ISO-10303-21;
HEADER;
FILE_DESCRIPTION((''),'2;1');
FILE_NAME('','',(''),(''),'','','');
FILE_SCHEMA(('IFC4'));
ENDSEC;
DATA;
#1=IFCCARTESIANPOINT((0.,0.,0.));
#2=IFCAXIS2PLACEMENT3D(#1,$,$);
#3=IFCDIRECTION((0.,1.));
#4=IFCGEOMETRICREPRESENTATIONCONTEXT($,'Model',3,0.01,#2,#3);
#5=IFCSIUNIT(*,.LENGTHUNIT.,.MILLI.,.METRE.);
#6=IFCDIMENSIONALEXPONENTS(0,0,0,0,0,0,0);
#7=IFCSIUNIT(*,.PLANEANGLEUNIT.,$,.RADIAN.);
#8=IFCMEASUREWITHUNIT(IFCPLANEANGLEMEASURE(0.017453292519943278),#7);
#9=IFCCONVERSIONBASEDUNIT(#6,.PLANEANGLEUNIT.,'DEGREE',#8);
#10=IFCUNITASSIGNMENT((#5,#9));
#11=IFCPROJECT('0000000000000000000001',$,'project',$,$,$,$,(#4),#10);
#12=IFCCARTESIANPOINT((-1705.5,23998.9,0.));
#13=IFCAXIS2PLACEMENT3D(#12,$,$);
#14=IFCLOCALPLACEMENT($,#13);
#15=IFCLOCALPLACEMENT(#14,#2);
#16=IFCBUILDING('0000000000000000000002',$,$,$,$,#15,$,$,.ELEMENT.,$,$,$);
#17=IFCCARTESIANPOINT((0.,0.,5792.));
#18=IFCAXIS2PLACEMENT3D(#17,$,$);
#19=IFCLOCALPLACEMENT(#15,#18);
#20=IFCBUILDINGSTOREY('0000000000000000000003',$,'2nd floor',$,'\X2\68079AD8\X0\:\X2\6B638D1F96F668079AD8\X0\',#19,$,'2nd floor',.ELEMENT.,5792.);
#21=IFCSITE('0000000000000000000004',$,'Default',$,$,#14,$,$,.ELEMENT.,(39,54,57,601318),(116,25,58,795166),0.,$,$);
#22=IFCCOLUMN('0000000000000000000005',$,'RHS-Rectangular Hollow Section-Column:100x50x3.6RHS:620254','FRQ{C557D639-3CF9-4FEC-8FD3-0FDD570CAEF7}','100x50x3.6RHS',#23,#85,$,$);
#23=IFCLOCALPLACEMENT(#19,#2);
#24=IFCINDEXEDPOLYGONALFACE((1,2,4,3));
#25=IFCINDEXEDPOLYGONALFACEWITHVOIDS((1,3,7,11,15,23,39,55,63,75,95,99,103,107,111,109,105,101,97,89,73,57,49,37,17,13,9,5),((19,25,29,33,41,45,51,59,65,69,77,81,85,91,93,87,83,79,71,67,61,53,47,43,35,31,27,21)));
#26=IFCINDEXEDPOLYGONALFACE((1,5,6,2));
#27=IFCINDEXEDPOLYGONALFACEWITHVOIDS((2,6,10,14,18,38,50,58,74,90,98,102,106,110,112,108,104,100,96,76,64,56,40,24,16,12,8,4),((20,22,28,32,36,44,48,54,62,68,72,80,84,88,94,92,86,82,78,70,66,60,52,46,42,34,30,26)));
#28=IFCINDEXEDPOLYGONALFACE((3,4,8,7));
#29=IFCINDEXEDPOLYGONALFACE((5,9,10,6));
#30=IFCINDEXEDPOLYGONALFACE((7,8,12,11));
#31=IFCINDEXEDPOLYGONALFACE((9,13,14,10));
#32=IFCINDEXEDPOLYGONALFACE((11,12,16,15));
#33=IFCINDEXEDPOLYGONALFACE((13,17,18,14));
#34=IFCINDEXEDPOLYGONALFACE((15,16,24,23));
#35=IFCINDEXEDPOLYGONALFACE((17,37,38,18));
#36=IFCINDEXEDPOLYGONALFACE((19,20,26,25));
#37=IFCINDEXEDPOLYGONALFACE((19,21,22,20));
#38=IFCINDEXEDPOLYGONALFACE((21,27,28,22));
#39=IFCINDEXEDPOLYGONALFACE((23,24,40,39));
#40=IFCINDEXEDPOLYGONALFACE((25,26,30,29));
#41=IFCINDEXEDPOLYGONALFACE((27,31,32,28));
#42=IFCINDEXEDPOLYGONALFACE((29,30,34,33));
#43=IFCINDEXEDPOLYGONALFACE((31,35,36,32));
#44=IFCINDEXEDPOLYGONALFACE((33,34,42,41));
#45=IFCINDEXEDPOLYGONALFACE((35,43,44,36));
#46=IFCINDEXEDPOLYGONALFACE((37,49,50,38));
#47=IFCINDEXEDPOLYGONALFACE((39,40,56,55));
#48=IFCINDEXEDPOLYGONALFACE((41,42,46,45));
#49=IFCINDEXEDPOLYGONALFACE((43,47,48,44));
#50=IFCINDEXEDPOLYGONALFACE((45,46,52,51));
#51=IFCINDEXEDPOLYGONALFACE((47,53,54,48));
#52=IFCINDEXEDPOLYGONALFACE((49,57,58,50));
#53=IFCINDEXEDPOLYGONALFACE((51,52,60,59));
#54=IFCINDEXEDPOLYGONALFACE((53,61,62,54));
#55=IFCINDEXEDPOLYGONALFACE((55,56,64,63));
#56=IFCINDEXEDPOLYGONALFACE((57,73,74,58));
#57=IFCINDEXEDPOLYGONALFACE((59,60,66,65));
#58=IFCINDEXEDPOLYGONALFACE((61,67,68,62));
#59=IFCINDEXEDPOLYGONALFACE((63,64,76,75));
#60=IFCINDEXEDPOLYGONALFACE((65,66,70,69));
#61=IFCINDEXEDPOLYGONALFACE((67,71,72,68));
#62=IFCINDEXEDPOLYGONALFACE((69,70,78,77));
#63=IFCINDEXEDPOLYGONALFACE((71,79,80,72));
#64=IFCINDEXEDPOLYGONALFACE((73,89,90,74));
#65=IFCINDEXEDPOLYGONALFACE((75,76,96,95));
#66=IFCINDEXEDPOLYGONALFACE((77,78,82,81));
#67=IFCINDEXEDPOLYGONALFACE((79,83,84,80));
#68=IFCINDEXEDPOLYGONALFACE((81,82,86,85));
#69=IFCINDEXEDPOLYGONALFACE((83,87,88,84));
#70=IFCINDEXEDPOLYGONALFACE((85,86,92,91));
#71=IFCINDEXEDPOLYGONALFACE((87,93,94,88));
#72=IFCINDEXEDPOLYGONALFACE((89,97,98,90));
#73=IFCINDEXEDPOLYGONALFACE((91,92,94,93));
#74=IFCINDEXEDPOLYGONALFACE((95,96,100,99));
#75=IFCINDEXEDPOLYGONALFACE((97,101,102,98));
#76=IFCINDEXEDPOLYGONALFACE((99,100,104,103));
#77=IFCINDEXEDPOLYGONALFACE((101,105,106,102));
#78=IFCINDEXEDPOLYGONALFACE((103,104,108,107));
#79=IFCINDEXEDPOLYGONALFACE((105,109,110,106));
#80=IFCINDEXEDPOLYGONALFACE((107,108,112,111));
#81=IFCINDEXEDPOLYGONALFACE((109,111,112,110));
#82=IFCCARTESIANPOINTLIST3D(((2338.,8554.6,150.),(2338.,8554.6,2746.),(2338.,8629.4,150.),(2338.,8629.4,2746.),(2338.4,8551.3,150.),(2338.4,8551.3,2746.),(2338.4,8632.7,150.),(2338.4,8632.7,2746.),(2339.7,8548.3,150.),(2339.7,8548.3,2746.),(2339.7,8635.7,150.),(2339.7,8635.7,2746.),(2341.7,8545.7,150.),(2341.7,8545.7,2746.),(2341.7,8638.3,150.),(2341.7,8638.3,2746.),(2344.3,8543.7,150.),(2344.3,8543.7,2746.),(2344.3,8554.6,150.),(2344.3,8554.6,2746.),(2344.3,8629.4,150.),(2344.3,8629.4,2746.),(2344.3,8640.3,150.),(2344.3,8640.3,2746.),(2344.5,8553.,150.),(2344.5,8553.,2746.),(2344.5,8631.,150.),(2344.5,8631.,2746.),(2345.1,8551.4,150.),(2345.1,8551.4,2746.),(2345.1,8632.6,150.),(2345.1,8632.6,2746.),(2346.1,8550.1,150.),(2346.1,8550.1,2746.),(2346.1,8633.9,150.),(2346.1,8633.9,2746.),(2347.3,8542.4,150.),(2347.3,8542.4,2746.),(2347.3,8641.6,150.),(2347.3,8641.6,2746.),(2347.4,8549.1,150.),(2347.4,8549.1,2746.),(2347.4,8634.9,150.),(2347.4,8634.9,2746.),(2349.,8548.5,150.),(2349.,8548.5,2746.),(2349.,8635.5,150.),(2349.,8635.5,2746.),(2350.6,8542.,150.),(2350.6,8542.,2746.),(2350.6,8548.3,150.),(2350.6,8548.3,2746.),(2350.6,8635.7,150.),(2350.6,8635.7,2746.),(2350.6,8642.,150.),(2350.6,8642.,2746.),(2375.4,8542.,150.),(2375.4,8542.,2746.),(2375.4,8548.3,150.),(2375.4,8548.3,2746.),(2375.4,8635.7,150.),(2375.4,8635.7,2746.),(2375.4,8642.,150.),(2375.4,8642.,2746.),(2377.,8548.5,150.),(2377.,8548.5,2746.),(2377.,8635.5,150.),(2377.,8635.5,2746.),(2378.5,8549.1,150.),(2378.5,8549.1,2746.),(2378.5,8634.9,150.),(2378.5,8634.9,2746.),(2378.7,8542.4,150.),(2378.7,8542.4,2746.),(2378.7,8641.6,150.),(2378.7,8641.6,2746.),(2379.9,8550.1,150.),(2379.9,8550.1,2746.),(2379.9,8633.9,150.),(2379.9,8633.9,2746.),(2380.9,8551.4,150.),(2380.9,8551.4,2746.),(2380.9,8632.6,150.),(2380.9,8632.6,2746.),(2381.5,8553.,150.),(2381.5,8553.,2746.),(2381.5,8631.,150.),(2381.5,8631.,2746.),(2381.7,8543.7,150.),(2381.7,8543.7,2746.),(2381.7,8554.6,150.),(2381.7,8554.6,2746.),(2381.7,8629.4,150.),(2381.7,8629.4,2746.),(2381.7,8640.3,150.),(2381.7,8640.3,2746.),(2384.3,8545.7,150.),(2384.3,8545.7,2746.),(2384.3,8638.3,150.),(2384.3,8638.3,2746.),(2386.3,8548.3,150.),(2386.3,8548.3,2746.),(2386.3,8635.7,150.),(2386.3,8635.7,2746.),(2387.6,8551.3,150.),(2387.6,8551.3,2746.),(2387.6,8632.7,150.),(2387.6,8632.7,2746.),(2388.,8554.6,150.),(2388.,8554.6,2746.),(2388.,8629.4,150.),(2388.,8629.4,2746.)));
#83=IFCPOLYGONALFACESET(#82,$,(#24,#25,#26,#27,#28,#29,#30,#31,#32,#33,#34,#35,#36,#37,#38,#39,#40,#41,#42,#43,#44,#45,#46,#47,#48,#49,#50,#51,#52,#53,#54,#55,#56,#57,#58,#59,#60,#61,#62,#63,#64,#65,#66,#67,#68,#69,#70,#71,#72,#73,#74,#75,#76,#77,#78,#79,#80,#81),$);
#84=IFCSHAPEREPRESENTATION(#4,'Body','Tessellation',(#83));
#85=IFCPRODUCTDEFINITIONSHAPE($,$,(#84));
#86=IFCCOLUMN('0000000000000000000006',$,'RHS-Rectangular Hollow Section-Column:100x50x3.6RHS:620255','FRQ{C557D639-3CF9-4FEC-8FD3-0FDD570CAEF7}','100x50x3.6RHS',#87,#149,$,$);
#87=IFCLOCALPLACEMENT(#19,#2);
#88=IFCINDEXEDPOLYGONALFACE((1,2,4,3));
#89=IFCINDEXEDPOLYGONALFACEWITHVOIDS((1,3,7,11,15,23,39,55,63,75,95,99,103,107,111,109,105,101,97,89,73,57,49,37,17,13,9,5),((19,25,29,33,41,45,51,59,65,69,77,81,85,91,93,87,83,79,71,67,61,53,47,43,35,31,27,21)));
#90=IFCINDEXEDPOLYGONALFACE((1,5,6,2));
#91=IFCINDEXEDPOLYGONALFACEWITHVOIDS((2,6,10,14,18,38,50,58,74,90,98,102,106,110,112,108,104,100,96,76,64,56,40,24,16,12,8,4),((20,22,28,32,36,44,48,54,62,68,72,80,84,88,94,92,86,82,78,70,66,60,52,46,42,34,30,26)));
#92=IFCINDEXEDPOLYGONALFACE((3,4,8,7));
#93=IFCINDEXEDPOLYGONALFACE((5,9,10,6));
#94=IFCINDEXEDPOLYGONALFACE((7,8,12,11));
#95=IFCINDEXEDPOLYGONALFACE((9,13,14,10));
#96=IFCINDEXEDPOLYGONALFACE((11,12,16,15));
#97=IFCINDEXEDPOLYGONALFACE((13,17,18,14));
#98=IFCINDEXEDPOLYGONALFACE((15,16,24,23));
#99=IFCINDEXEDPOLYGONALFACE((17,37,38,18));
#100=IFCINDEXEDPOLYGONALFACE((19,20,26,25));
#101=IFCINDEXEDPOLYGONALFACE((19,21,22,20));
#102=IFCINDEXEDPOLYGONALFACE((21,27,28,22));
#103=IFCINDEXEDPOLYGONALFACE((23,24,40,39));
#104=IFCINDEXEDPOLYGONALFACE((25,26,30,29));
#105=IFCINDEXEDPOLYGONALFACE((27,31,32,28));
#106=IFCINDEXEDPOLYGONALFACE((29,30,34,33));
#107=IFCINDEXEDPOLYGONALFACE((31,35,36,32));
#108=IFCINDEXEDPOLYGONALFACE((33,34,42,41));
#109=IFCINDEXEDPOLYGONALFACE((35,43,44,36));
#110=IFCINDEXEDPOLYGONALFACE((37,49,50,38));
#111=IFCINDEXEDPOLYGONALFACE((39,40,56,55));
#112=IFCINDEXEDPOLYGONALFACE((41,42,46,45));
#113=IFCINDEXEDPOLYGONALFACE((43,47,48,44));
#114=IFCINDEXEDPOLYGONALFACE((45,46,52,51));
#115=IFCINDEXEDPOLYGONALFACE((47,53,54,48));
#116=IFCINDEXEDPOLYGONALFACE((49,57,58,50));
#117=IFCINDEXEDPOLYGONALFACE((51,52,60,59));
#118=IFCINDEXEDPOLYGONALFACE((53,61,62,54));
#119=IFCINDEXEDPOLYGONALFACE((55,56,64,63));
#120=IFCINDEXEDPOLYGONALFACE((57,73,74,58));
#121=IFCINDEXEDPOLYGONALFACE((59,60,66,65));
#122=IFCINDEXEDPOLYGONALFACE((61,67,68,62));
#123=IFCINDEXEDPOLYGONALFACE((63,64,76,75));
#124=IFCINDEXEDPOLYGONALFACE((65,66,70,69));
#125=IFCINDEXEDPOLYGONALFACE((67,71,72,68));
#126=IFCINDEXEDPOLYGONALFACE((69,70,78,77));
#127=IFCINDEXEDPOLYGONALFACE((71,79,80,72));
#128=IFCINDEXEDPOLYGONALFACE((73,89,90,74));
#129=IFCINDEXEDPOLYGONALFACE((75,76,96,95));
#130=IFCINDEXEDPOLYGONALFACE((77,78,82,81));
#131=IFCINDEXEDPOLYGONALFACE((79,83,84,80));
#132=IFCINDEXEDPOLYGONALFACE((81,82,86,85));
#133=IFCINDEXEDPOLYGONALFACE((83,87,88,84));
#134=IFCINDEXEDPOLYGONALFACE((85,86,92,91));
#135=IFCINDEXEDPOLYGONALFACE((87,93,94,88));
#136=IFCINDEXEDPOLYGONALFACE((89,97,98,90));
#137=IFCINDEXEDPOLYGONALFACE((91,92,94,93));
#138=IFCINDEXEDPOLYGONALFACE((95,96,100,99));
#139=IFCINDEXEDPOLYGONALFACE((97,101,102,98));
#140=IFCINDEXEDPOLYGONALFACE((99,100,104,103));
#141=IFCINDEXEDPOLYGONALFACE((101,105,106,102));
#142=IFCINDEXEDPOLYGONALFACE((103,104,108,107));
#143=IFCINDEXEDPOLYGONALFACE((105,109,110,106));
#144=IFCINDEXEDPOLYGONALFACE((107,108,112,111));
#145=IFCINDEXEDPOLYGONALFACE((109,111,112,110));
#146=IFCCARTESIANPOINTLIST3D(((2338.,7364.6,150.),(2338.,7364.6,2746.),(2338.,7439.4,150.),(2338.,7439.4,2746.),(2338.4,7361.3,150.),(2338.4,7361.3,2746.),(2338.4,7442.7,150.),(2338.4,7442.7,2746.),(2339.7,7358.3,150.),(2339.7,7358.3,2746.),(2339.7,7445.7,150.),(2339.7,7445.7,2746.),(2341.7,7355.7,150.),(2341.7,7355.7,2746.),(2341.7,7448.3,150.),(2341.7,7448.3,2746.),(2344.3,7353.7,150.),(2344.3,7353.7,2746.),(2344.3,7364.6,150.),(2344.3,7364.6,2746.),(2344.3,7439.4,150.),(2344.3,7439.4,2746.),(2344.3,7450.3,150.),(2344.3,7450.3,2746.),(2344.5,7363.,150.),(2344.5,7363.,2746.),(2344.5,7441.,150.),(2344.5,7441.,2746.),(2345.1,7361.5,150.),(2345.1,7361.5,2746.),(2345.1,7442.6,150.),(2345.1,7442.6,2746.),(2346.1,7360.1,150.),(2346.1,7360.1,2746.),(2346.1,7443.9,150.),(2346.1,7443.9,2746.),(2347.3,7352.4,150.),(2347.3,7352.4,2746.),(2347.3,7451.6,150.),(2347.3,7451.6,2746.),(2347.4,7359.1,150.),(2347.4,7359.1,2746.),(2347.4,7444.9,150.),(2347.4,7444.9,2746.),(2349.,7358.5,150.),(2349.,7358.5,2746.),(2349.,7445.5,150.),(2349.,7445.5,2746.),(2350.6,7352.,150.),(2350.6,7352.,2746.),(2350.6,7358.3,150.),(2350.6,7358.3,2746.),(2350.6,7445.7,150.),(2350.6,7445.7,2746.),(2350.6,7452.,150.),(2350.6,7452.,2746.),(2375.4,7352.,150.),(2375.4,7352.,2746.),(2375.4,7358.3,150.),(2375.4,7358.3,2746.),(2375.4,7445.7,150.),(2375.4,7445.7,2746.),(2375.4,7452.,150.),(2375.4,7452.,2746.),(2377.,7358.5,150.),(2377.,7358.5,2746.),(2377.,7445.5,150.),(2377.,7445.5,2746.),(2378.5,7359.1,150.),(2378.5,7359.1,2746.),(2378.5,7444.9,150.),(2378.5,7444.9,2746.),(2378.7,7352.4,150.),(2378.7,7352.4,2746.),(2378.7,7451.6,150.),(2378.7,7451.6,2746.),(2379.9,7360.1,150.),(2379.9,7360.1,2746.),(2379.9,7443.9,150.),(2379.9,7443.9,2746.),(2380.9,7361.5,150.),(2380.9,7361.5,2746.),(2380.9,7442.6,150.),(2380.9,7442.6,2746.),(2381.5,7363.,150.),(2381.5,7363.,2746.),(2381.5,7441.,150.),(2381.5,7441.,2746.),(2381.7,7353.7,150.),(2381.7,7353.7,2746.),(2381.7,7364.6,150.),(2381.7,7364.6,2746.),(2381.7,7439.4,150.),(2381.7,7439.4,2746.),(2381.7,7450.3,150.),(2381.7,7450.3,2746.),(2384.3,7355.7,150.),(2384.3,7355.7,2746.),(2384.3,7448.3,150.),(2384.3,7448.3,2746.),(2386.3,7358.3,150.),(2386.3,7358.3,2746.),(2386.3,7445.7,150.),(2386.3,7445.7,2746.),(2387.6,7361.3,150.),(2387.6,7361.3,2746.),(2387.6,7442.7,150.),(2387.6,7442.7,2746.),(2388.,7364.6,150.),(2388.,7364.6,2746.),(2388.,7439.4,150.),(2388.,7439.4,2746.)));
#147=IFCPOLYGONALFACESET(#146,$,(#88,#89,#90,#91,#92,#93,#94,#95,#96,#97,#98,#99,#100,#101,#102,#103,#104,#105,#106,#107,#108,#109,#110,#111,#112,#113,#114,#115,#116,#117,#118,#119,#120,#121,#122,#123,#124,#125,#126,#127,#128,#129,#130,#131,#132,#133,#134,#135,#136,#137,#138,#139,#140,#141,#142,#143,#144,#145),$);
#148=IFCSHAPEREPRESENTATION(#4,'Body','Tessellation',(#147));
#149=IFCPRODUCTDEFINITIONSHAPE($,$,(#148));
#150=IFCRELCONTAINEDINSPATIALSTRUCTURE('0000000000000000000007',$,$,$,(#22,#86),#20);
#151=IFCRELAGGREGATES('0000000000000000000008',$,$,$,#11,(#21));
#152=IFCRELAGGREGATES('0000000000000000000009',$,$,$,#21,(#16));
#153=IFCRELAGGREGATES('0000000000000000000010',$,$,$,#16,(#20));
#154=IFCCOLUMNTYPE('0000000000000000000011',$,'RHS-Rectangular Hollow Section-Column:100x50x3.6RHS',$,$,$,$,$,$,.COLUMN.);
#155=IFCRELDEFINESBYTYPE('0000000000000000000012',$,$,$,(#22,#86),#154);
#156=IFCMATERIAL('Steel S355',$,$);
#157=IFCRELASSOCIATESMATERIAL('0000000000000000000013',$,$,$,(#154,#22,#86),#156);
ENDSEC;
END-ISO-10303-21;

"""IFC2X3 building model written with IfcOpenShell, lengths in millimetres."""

from ifc_helpers import new_model, entity, si_unit, converted_unit, direction, frame, origin, origin_2d, place, context, project, spatial, hollow_rectangle, extrude, clip, halfspace, material, type_object, element, save


model = new_model("IFC2X3")

# Units and contexts
model_context = context("Model", 3, precision=0.01, world=origin(), true_north=direction((0.0, 1.0)))
ifc_project = project(units=[si_unit("LENGTHUNIT", "METRE", prefix="MILLI"), converted_unit("PLANEANGLEUNIT", "DEGREE", entity("IfcPlaneAngleMeasure", 0.017453292519943278), si_unit("PLANEANGLEUNIT", "RADIAN"), dimensions=[0, 0, 0, 0, 0, 0, 0])], contexts=[model_context])

# Site, building, storey
site_placement = place(None, frame((-1705.5, 23998.9, 0.0)))
site = spatial("IfcSite", under=ifc_project, at=site_placement, Name="Default", CompositionType="ELEMENT", RefLatitude=(39, 54, 57, 601318), RefLongitude=(116, 25, 58, 795166), RefElevation=0.0)
building_placement = place(site_placement, origin())
building = spatial("IfcBuilding", under=site, at=building_placement, CompositionType="ELEMENT")
storey_placement = place(building_placement, frame((0.0, 0.0, 5792.0)))
storey = spatial("IfcBuildingStorey", under=building, at=storey_placement, Name="2nd floor", ObjectType="标高:正负零标高", LongName="2nd floor", CompositionType="ELEMENT", Elevation=5792.0)

# Columns
ifc_material_1 = material(Name="Steel S355")
column_type = type_object("IfcColumnType", Name="RHS-Rectangular Hollow Section-Column:100x50x3.6RHS", PredefinedType="COLUMN", material=ifc_material_1)
column_1_placement = place(storey_placement, frame((2363.0, 8592.0, 2746.0), z_axis=(0.0, 0.0, 1.0), x_axis=(-1.0, 0.0, 0.0)))
element("IfcColumn", 1, at=column_1_placement, inside=storey, type_object=column_type, material=ifc_material_1, Name="RHS-Rectangular Hollow Section-Column:100x50x3.6RHS:620254", Description="FRQ{C557D639-3CF9-4FEC-8FD3-0FDD570CAEF7}", ObjectType="100x50x3.6RHS", context=model_context, shape_type="Clipping", body=[
    clip(extrude(hollow_rectangle(XDim=50.0, YDim=100.0, WallThickness=6.3, InnerFilletRadius=6.3, OuterFilletRadius=12.6, at=origin_2d()), origin(), (0.0, 0.0, -1.0), 2651.9), halfspace(frame((2363.0, 8592.0, -2596.0), z_axis=(0.0, 0.0, 1.0), x_axis=(-1.0, 0.0, 0.0)), True)),
])
column_2_placement = place(storey_placement, frame((2363.0, 7402.0, 2746.0), z_axis=(0.0, 0.0, 1.0), x_axis=(-1.0, 0.0, 0.0)))
element("IfcColumn", 2, at=column_2_placement, inside=storey, type_object=column_type, material=ifc_material_1, Name="RHS-Rectangular Hollow Section-Column:100x50x3.6RHS:620255", Description="FRQ{C557D639-3CF9-4FEC-8FD3-0FDD570CAEF7}", ObjectType="100x50x3.6RHS", context=model_context, shape_type="Clipping", body=[
    clip(extrude(hollow_rectangle(XDim=50.0, YDim=100.0, WallThickness=6.3, InnerFilletRadius=6.3, OuterFilletRadius=12.6, at=origin_2d()), origin(), (0.0, 0.0, -1.0), 2651.9), halfspace(frame((2363.0, 7402.0, -2596.0), z_axis=(0.0, 0.0, 1.0), x_axis=(-1.0, 0.0, 0.0)), True)),
])

save(model, "model.ifc")
